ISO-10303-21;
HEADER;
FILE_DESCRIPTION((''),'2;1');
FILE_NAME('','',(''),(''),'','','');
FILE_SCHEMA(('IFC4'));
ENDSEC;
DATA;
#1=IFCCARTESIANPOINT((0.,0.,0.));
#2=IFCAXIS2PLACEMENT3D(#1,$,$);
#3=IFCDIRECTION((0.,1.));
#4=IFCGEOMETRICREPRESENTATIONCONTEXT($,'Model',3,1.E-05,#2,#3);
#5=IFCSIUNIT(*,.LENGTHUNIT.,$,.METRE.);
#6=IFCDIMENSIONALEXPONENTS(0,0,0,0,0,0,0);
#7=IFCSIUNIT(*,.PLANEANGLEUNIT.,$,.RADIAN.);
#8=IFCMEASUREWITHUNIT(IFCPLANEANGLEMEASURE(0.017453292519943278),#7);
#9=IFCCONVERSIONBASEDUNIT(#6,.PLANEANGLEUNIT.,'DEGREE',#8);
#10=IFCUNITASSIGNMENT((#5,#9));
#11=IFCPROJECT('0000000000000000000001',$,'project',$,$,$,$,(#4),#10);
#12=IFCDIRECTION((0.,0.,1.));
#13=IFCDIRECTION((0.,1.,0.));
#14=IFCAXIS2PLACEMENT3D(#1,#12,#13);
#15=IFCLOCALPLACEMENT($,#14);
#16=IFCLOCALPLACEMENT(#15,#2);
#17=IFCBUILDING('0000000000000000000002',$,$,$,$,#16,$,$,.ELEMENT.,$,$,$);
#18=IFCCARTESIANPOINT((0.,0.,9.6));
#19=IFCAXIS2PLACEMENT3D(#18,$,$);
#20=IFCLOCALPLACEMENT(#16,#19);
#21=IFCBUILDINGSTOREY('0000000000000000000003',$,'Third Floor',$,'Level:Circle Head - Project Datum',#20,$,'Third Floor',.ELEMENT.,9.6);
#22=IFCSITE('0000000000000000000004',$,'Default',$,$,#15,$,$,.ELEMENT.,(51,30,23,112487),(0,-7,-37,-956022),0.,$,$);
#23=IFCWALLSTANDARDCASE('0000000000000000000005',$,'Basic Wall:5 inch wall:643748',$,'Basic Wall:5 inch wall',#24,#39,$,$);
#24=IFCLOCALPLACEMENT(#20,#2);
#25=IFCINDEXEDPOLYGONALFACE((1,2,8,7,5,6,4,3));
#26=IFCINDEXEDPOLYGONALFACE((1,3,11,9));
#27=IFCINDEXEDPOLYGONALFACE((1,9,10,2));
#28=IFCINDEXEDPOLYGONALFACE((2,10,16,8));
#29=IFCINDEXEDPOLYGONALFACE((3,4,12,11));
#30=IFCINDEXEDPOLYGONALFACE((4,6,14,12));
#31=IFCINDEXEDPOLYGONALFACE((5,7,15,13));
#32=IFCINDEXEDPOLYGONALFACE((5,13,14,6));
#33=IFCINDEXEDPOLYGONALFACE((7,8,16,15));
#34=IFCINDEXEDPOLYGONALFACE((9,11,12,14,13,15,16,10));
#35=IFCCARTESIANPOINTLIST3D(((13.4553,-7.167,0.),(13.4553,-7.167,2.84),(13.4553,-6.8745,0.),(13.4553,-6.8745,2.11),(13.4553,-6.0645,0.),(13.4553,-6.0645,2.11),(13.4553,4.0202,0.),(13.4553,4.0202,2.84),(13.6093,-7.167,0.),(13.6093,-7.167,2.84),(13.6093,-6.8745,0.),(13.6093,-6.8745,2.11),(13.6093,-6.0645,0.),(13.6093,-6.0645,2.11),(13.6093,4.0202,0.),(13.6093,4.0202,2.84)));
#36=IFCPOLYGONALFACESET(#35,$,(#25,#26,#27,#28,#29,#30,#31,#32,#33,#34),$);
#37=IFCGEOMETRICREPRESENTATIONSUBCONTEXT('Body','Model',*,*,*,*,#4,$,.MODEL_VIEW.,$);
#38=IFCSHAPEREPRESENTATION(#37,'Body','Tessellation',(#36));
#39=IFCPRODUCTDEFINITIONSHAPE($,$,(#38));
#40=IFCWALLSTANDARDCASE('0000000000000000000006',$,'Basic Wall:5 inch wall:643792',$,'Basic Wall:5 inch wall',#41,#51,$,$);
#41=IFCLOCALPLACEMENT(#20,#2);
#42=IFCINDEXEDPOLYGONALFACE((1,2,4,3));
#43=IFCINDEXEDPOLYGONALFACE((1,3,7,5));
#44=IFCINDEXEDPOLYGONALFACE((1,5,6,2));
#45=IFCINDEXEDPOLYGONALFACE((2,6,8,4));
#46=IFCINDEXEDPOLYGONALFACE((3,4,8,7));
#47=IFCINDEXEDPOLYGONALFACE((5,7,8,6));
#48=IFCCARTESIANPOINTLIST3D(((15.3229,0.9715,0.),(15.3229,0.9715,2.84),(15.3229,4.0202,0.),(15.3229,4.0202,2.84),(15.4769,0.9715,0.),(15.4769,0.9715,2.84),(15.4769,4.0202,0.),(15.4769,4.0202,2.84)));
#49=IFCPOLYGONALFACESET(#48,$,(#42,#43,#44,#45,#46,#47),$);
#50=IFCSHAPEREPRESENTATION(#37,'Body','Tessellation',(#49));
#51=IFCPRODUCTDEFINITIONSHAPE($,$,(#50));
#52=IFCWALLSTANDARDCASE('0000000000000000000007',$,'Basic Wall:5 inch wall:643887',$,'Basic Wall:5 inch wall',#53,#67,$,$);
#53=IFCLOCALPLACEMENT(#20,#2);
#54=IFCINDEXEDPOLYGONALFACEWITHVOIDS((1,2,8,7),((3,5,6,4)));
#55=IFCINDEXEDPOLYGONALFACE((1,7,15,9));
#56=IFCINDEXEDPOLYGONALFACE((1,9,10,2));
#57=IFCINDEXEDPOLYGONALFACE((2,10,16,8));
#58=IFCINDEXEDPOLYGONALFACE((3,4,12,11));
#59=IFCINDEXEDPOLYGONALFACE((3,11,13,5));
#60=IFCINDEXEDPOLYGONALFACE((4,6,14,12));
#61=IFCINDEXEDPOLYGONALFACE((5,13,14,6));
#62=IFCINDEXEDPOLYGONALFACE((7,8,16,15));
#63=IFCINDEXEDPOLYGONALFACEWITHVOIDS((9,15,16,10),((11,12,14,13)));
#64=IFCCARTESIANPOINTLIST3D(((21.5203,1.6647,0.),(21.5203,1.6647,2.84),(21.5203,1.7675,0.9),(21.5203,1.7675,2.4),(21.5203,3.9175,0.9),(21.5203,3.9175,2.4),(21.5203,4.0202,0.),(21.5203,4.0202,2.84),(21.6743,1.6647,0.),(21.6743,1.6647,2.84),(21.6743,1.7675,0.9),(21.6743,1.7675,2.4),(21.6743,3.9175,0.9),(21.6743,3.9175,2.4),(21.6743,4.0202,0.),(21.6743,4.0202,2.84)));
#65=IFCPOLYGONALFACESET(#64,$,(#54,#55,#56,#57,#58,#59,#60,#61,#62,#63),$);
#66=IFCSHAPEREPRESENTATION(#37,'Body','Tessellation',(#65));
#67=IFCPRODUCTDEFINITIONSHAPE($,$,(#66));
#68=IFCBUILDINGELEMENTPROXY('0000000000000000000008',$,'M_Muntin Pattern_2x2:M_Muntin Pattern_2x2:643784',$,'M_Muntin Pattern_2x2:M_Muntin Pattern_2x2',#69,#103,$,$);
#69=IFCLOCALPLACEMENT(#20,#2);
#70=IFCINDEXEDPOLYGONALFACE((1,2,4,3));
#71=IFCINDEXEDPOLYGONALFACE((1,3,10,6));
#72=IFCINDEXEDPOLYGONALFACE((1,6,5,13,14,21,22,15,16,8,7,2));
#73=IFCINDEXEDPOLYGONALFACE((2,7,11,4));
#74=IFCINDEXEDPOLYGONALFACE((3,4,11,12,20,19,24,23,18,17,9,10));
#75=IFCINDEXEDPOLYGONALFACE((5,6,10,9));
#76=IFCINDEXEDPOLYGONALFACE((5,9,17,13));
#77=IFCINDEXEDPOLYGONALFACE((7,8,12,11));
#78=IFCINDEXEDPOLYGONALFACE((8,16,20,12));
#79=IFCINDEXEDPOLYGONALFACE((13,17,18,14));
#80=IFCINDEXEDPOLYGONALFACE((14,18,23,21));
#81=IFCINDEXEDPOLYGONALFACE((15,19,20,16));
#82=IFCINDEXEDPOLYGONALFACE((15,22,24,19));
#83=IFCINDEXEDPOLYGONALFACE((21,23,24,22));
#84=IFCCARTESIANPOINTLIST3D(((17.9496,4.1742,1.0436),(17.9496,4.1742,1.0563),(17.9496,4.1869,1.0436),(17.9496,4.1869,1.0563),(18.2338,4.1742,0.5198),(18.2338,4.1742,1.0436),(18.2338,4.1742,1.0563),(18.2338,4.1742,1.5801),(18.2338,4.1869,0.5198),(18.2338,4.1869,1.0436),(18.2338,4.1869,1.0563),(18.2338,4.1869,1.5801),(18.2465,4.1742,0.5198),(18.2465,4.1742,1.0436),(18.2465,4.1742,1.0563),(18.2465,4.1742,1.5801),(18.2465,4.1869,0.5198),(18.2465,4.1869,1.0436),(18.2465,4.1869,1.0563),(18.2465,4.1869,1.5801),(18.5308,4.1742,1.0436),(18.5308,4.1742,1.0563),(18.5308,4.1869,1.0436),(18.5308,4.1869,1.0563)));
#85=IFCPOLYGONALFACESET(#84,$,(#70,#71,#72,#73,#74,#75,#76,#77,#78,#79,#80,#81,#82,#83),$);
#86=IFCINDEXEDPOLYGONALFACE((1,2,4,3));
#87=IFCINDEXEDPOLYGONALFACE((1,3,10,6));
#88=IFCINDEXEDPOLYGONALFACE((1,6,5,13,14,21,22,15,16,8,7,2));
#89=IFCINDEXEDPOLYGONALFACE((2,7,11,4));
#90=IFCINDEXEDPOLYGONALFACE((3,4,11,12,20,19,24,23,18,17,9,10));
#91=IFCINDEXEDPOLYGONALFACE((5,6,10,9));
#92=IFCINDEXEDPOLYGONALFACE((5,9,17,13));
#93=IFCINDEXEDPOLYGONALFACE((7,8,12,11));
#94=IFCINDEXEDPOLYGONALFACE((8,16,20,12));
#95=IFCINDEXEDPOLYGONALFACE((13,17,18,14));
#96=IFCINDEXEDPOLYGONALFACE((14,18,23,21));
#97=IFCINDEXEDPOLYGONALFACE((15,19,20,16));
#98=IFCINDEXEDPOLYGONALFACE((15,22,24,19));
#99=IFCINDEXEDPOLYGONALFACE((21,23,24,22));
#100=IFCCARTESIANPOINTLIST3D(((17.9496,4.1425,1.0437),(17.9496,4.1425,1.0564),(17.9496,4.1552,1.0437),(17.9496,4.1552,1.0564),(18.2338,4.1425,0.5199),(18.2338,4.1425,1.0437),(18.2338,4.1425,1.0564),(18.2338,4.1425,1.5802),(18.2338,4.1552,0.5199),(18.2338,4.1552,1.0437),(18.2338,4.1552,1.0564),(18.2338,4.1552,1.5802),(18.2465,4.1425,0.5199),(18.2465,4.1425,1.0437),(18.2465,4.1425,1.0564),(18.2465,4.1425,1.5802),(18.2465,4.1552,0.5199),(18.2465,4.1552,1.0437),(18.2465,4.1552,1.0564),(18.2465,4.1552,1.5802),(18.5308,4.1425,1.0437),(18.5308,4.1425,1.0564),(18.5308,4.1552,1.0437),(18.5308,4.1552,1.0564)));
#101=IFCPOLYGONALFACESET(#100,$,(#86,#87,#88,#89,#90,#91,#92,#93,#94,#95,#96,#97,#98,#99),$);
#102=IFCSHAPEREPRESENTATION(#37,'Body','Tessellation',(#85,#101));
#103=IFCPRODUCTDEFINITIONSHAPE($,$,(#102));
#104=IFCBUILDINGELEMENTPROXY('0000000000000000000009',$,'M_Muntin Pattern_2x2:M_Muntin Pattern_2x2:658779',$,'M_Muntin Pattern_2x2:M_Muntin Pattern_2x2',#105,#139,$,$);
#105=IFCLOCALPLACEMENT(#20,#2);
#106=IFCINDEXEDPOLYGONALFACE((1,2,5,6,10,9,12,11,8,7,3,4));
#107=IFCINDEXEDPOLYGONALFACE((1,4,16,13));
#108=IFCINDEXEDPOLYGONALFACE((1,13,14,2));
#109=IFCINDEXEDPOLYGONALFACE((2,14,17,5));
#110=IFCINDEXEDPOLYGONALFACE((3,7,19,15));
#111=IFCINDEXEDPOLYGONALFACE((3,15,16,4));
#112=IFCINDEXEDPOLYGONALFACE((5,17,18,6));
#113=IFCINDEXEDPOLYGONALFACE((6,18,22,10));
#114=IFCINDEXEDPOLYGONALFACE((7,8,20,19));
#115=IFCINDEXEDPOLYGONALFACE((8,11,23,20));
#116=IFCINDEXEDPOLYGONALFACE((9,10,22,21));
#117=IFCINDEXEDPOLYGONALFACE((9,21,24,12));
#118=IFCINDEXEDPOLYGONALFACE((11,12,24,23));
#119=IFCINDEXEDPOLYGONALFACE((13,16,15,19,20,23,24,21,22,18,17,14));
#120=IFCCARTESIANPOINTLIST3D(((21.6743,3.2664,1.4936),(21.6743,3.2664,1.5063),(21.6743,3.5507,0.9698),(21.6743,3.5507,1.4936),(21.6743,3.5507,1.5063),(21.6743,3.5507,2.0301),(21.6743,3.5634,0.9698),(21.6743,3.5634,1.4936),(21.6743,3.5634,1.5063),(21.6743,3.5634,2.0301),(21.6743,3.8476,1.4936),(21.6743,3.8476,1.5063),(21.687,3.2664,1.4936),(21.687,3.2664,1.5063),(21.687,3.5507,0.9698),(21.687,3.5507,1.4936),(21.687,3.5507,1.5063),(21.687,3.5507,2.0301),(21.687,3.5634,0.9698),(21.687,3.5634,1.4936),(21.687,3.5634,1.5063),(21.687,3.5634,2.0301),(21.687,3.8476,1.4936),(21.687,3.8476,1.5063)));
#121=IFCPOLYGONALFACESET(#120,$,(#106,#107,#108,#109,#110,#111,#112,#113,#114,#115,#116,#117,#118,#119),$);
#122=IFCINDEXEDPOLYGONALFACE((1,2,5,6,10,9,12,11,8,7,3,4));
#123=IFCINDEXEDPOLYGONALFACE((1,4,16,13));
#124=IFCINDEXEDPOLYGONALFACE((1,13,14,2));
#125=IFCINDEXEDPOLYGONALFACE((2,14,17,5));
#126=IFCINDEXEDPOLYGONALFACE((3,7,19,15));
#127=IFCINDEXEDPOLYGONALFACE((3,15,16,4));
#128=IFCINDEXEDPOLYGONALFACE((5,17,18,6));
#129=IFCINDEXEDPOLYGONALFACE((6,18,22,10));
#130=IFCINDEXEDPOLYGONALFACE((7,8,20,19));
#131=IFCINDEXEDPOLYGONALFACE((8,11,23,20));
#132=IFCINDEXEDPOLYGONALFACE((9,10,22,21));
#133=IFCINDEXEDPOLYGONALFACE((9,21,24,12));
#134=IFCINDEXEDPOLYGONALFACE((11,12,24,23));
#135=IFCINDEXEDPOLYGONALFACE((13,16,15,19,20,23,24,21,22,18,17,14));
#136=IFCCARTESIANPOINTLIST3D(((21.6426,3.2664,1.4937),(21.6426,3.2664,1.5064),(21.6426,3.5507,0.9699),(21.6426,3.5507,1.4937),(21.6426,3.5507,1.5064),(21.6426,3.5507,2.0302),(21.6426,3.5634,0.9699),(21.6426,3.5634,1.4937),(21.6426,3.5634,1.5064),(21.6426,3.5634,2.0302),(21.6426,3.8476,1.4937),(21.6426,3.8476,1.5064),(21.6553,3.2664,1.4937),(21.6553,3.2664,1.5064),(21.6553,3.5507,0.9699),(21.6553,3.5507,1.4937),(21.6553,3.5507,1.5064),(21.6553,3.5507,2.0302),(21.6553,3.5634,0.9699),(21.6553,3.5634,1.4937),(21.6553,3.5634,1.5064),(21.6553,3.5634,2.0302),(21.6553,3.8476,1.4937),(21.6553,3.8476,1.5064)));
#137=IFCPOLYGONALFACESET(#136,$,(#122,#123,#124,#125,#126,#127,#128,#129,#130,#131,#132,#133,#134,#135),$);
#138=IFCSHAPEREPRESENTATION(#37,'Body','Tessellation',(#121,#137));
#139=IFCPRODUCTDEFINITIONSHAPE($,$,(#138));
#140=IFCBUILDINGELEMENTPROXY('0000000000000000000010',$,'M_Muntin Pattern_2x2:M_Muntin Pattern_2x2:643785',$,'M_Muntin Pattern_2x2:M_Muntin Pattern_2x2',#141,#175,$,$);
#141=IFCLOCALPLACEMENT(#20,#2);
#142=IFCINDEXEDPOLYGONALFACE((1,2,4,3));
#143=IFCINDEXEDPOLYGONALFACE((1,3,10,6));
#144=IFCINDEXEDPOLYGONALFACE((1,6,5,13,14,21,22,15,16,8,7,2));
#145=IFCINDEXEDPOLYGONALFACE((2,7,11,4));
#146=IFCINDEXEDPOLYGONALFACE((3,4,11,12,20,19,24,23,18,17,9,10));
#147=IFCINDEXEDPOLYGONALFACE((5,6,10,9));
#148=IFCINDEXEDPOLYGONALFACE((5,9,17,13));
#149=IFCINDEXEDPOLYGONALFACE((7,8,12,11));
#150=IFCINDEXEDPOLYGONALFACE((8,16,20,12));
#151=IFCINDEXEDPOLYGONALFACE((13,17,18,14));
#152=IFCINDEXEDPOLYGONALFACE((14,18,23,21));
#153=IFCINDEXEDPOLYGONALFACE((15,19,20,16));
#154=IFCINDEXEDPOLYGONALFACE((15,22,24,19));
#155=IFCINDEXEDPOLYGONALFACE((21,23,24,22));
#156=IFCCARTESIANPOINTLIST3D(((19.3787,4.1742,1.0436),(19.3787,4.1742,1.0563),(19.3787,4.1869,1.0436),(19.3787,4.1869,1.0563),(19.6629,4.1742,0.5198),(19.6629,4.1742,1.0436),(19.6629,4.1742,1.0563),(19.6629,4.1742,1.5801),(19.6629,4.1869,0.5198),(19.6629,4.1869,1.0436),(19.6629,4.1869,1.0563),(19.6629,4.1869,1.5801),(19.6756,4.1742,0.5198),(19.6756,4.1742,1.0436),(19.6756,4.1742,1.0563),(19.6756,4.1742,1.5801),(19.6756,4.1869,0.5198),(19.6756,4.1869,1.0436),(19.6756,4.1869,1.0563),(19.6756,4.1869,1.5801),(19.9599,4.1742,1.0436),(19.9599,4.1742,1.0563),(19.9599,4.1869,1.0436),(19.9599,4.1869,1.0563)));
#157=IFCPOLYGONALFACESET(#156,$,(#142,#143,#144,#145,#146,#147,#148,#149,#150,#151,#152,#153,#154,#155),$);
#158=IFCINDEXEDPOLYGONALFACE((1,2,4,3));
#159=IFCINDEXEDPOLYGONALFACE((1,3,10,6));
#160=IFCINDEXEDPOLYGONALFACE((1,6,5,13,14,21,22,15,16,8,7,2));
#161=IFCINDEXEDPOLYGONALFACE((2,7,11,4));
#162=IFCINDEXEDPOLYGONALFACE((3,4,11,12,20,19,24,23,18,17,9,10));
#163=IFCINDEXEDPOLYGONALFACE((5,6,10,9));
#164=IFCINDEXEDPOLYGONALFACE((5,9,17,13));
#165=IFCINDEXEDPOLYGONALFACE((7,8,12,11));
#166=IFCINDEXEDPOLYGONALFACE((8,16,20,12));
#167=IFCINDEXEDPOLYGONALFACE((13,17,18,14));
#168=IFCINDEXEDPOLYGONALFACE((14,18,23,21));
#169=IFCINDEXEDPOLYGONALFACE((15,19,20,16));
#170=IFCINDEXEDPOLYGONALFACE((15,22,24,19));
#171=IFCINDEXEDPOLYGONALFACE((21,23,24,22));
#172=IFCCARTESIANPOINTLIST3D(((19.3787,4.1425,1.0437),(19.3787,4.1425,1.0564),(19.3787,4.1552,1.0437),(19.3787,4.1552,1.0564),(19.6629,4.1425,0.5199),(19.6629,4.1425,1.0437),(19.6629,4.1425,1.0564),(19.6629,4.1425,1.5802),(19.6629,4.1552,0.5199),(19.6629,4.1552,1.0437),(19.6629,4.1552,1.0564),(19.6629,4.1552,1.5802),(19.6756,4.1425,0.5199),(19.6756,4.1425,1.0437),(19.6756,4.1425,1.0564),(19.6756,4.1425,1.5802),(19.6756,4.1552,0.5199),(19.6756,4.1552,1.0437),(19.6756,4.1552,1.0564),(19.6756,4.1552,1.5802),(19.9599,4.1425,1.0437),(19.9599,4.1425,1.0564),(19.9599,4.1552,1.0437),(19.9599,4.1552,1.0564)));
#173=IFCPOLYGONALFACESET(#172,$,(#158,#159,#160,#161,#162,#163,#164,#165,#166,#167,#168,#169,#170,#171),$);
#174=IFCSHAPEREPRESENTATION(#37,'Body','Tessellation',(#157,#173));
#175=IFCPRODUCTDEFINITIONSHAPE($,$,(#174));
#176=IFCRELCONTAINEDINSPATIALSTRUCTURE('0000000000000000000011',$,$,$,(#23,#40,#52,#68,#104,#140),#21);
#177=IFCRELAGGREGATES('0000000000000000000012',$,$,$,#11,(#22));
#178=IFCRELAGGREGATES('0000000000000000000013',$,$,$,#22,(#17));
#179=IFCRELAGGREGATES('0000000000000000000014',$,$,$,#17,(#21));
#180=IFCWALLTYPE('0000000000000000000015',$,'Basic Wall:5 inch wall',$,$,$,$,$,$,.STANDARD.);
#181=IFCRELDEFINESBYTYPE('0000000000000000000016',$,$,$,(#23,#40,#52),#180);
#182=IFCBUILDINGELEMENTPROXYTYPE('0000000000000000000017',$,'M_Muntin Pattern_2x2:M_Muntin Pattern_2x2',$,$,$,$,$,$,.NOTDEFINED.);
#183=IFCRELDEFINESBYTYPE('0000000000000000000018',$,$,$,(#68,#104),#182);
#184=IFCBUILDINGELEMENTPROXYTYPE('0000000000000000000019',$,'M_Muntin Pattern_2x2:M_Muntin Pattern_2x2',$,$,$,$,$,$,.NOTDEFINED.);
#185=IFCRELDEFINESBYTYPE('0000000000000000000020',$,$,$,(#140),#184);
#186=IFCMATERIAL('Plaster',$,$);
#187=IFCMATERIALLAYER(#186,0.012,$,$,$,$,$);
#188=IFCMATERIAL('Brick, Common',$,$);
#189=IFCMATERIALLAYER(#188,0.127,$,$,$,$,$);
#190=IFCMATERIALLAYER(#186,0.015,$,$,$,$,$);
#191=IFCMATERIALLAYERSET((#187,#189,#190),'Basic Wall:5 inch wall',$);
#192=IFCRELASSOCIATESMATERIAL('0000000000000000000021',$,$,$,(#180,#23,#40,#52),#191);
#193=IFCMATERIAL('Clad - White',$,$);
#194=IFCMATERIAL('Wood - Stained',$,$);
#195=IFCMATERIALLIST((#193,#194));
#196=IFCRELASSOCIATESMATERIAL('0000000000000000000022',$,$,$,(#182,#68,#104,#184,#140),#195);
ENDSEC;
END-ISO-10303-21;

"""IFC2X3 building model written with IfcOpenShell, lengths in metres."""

from ifc_helpers import new_model, entity, si_unit, converted_unit, direction, frame, frame_2d, origin, place, context, subcontext, project, spatial, polyline, rectangle, outline, extrude, source, transform, mapped, material, material_list, layer, layer_set, layer_usage, type_object, type_shapes, element, save


model = new_model("IFC2X3")

# Units and contexts
model_context = context("Model", 3, precision=1e-05, world=origin(), true_north=direction((0.0, 1.0)))
body_context = subcontext(model_context, "Body", "Model", "MODEL_VIEW")
ifc_project = project(units=[si_unit("LENGTHUNIT", "METRE"), converted_unit("PLANEANGLEUNIT", "DEGREE", entity("IfcPlaneAngleMeasure", 0.017453292519943278), si_unit("PLANEANGLEUNIT", "RADIAN"), dimensions=[0, 0, 0, 0, 0, 0, 0])], contexts=[model_context])

# Site, building, storey
site_placement = place(None, frame((0.0, 0.0, 0.0), z_axis=(0.0, 0.0, 1.0), x_axis=(0.0, 1.0, 0.0)))
site = spatial("IfcSite", under=ifc_project, at=site_placement, Name="Default", CompositionType="ELEMENT", RefLatitude=(51, 30, 23, 112487), RefLongitude=(0, -7, -37, -956022), RefElevation=0.0)
building_placement = place(site_placement, origin())
building = spatial("IfcBuilding", under=site, at=building_placement, CompositionType="ELEMENT")
storey_placement = place(building_placement, frame((0.0, 0.0, 9.6)))
storey = spatial("IfcBuildingStorey", under=building, at=storey_placement, Name="Third Floor", ObjectType="Level:Circle Head - Project Datum", LongName="Third Floor", CompositionType="ELEMENT", Elevation=9.6)

# Wall, opening
ifc_material_1 = material(Name="Plaster")
ifc_layer_1 = layer(ifc_material_1, 0.012)
ifc_material_2 = material(Name="Brick, Common")
ifc_layer_2 = layer(ifc_material_2, 0.127)
ifc_layer_3 = layer(ifc_material_1, 0.015)
ifc_layer_set = layer_set([ifc_layer_1, ifc_layer_2, ifc_layer_3], Name="Basic Wall:5 inch wall")
ifc_layer_usage_1 = layer_usage(ifc_layer_set, "AXIS2", "NEGATIVE", 0.077)
wall_type = type_object("IfcWallType", Name="Basic Wall:5 inch wall", PredefinedType="STANDARD", material=ifc_layer_set)
wall_1_placement = place(storey_placement, frame((13.5323, 4.0202, 0.0), z_axis=(0.0, 0.0, 1.0), x_axis=(0.0, -1.0, 0.0)))
wall_1 = element("IfcWallStandardCase", 1, at=wall_1_placement, inside=storey, type_object=wall_type, material=ifc_layer_usage_1, Name="Basic Wall:5 inch wall:643748", ObjectType="Basic Wall:5 inch wall", context=body_context, shape_type="SweptSolid", body=[
    extrude(rectangle(XDim=11.1872, YDim=0.154, at=frame_2d((5.5936, 0.0), x_axis=(-1.0, 0.0))), origin(), (0.0, 0.0, 1.0), 2.84),
])
opening_1_placement = place(wall_1_placement, frame((10.0847, -0.077, 0.0)))
element("IfcOpeningElement", 2, at=opening_1_placement, cuts=wall_1, ObjectType="Opening", context=body_context, shape_type="SweptSolid", body=[
    extrude(rectangle(XDim=2.11, YDim=0.81, at=frame_2d((1.055, 0.405), x_axis=(1.0, 0.0))), frame((0.0, 0.0, 0.0), z_axis=(0.0, 1.0, 0.0), x_axis=(0.0, 0.0, 1.0)), (0.0, 0.0, 1.0), 0.154),
])

# Wall
ifc_layer_usage_2 = layer_usage(ifc_layer_set, "AXIS2", "NEGATIVE", 0.077)
wall_2_placement = place(storey_placement, frame((15.3999, 4.0202, 0.0), z_axis=(0.0, 0.0, 1.0), x_axis=(0.0, -1.0, 0.0)))
element("IfcWallStandardCase", 3, at=wall_2_placement, inside=storey, type_object=wall_type, material=ifc_layer_usage_2, Name="Basic Wall:5 inch wall:643792", ObjectType="Basic Wall:5 inch wall", context=body_context, shape_type="SweptSolid", body=[
    extrude(rectangle(XDim=3.0487, YDim=0.154, at=frame_2d((1.5244, 0.0), x_axis=(-1.0, 0.0))), origin(), (0.0, 0.0, 1.0), 2.84),
])

# Wall, opening
ifc_layer_usage_3 = layer_usage(ifc_layer_set, "AXIS2", "NEGATIVE", 0.077)
wall_3_placement = place(storey_placement, frame((21.5973, 4.0202, 0.0), z_axis=(0.0, 0.0, 1.0), x_axis=(0.0, -1.0, 0.0)))
wall_3 = element("IfcWallStandardCase", 4, at=wall_3_placement, inside=storey, type_object=wall_type, material=ifc_layer_usage_3, Name="Basic Wall:5 inch wall:643887", ObjectType="Basic Wall:5 inch wall", context=body_context, shape_type="SweptSolid", body=[
    extrude(rectangle(XDim=2.3556, YDim=0.154, at=frame_2d((1.1778, 0.0), x_axis=(-1.0, 0.0))), origin(), (0.0, 0.0, 1.0), 2.84),
])
opening_2_placement = place(wall_3_placement, frame((0.1028, -0.077, 0.9)))
element("IfcOpeningElement", 5, at=opening_2_placement, cuts=wall_3, ObjectType="Opening", context=body_context, shape_type="SweptSolid", body=[
    extrude(rectangle(XDim=1.5, YDim=2.15, at=frame_2d((0.75, 1.075), x_axis=(-1.0, 0.0))), frame((0.0, 0.0, 0.0), z_axis=(0.0, 1.0, 0.0), x_axis=(0.0, 0.0, 1.0)), (0.0, 0.0, 1.0), 0.154),
])

# Building element proxies
ifc_material_3 = material(Name="Clad - White")
ifc_material_4 = material(Name="Wood - Stained")
ifc_material_list = material_list([ifc_material_3, ifc_material_4])
building_element_proxy_type_1 = type_object("IfcBuildingElementProxyType", Name="M_Muntin Pattern_2x2:M_Muntin Pattern_2x2", PredefinedType="NOTDEFINED", material=ifc_material_list)
shared_shape_1 = source(origin(), body_context, "Body", "SweptSolid", [
    extrude(outline(polyline([(0.0064, -0.0064), (0.5301, -0.0064), (0.5301, 0.0063), (0.0064, 0.0063), (0.0064, 0.2906), (-0.0063, 0.2906), (-0.0063, 0.0063), (-0.5302, 0.0063), (-0.5302, -0.0064), (-0.0063, -0.0064), (-0.0063, -0.2906), (0.0064, -0.2906), (0.0064, -0.0064)])), frame((0.0, 0.0095, 0.5301), z_axis=(0.0, 1.0, 0.0), x_axis=(0.0, 0.0, 1.0)), (0.0, 0.0, 1.0), 0.0127),
    extrude(outline(polyline([(0.0064, -0.0064), (0.5302, -0.0064), (0.5302, 0.0063), (0.0064, 0.0063), (0.0064, 0.2906), (-0.0063, 0.2906), (-0.0063, 0.0063), (-0.5302, 0.0063), (-0.5302, -0.0064), (-0.0063, -0.0064), (-0.0063, -0.2906), (0.0064, -0.2906), (0.0064, -0.0064)])), frame((0.0, -0.0222, 0.5302), z_axis=(0.0, 1.0, 0.0), x_axis=(0.0, 0.0, 1.0)), (0.0, 0.0, 1.0), 0.0127),
])
type_shapes(building_element_proxy_type_1, [shared_shape_1])
proxy_1_placement = place(storey_placement, frame((18.2402, 4.1647, 0.5199)))
element("IfcBuildingElementProxy", 6, at=proxy_1_placement, inside=storey, type_object=building_element_proxy_type_1, material=ifc_material_list, Name="M_Muntin Pattern_2x2:M_Muntin Pattern_2x2:643784", ObjectType="M_Muntin Pattern_2x2:M_Muntin Pattern_2x2", context=body_context, shape_type="MappedRepresentation", body=[
    mapped(shared_shape_1, transform((0.0, 0.0, 0.0), scale=1.0)),
])
proxy_2_placement = place(storey_placement, frame((21.6648, 3.557, 0.9699), z_axis=(0.0, 0.0, 1.0), x_axis=(0.0, -1.0, 0.0)))
element("IfcBuildingElementProxy", 7, at=proxy_2_placement, inside=storey, type_object=building_element_proxy_type_1, material=ifc_material_list, Name="M_Muntin Pattern_2x2:M_Muntin Pattern_2x2:658779", ObjectType="M_Muntin Pattern_2x2:M_Muntin Pattern_2x2", context=body_context, shape_type="MappedRepresentation", body=[
    mapped(shared_shape_1, transform((0.0, 0.0, 0.0), scale=1.0)),
])
building_element_proxy_type_2 = type_object("IfcBuildingElementProxyType", Name="M_Muntin Pattern_2x2:M_Muntin Pattern_2x2", PredefinedType="NOTDEFINED", material=ifc_material_list)
shared_shape_2 = source(origin(), body_context, "Body", "SweptSolid", [
    extrude(outline(polyline([(0.0064, -0.0064), (0.5301, -0.0064), (0.5301, 0.0063), (0.0064, 0.0063), (0.0064, 0.2906), (-0.0063, 0.2906), (-0.0063, 0.0063), (-0.5302, 0.0063), (-0.5302, -0.0064), (-0.0063, -0.0064), (-0.0063, -0.2906), (0.0064, -0.2906), (0.0064, -0.0064)])), frame((0.0, -0.0222, 0.5301), z_axis=(0.0, 1.0, 0.0), x_axis=(0.0, 0.0, 1.0)), (0.0, 0.0, 1.0), 0.0127),
    extrude(outline(polyline([(0.0064, -0.0064), (0.5302, -0.0064), (0.5302, 0.0063), (0.0064, 0.0063), (0.0064, 0.2906), (-0.0063, 0.2906), (-0.0063, 0.0063), (-0.5302, 0.0063), (-0.5302, -0.0064), (-0.0063, -0.0064), (-0.0063, -0.2906), (0.0064, -0.2906), (0.0064, -0.0064)])), frame((0.0, 0.0095, 0.5302), z_axis=(0.0, 1.0, 0.0), x_axis=(0.0, 0.0, 1.0)), (0.0, 0.0, 1.0), 0.0127),
])
type_shapes(building_element_proxy_type_2, [shared_shape_2])
for number, where, z_axis, x_axis, name in (
    (8, (19.6693, 4.1647, 0.5199), (0.0, 0.0, 1.0), (-1.0, 0.0, 0.0), "M_Muntin Pattern_2x2:M_Muntin Pattern_2x2:643785"),
):
    element("IfcBuildingElementProxy", number, at=place(storey_placement, frame(where, z_axis=z_axis, x_axis=x_axis)), inside=storey, type_object=building_element_proxy_type_2, material=ifc_material_list, Name=name, ObjectType="M_Muntin Pattern_2x2:M_Muntin Pattern_2x2", context=body_context, shape_type="MappedRepresentation", body=[
        mapped(shared_shape_2, transform((0.0, 0.0, 0.0), scale=1.0)),
    ])

save(model, "model.ifc")
